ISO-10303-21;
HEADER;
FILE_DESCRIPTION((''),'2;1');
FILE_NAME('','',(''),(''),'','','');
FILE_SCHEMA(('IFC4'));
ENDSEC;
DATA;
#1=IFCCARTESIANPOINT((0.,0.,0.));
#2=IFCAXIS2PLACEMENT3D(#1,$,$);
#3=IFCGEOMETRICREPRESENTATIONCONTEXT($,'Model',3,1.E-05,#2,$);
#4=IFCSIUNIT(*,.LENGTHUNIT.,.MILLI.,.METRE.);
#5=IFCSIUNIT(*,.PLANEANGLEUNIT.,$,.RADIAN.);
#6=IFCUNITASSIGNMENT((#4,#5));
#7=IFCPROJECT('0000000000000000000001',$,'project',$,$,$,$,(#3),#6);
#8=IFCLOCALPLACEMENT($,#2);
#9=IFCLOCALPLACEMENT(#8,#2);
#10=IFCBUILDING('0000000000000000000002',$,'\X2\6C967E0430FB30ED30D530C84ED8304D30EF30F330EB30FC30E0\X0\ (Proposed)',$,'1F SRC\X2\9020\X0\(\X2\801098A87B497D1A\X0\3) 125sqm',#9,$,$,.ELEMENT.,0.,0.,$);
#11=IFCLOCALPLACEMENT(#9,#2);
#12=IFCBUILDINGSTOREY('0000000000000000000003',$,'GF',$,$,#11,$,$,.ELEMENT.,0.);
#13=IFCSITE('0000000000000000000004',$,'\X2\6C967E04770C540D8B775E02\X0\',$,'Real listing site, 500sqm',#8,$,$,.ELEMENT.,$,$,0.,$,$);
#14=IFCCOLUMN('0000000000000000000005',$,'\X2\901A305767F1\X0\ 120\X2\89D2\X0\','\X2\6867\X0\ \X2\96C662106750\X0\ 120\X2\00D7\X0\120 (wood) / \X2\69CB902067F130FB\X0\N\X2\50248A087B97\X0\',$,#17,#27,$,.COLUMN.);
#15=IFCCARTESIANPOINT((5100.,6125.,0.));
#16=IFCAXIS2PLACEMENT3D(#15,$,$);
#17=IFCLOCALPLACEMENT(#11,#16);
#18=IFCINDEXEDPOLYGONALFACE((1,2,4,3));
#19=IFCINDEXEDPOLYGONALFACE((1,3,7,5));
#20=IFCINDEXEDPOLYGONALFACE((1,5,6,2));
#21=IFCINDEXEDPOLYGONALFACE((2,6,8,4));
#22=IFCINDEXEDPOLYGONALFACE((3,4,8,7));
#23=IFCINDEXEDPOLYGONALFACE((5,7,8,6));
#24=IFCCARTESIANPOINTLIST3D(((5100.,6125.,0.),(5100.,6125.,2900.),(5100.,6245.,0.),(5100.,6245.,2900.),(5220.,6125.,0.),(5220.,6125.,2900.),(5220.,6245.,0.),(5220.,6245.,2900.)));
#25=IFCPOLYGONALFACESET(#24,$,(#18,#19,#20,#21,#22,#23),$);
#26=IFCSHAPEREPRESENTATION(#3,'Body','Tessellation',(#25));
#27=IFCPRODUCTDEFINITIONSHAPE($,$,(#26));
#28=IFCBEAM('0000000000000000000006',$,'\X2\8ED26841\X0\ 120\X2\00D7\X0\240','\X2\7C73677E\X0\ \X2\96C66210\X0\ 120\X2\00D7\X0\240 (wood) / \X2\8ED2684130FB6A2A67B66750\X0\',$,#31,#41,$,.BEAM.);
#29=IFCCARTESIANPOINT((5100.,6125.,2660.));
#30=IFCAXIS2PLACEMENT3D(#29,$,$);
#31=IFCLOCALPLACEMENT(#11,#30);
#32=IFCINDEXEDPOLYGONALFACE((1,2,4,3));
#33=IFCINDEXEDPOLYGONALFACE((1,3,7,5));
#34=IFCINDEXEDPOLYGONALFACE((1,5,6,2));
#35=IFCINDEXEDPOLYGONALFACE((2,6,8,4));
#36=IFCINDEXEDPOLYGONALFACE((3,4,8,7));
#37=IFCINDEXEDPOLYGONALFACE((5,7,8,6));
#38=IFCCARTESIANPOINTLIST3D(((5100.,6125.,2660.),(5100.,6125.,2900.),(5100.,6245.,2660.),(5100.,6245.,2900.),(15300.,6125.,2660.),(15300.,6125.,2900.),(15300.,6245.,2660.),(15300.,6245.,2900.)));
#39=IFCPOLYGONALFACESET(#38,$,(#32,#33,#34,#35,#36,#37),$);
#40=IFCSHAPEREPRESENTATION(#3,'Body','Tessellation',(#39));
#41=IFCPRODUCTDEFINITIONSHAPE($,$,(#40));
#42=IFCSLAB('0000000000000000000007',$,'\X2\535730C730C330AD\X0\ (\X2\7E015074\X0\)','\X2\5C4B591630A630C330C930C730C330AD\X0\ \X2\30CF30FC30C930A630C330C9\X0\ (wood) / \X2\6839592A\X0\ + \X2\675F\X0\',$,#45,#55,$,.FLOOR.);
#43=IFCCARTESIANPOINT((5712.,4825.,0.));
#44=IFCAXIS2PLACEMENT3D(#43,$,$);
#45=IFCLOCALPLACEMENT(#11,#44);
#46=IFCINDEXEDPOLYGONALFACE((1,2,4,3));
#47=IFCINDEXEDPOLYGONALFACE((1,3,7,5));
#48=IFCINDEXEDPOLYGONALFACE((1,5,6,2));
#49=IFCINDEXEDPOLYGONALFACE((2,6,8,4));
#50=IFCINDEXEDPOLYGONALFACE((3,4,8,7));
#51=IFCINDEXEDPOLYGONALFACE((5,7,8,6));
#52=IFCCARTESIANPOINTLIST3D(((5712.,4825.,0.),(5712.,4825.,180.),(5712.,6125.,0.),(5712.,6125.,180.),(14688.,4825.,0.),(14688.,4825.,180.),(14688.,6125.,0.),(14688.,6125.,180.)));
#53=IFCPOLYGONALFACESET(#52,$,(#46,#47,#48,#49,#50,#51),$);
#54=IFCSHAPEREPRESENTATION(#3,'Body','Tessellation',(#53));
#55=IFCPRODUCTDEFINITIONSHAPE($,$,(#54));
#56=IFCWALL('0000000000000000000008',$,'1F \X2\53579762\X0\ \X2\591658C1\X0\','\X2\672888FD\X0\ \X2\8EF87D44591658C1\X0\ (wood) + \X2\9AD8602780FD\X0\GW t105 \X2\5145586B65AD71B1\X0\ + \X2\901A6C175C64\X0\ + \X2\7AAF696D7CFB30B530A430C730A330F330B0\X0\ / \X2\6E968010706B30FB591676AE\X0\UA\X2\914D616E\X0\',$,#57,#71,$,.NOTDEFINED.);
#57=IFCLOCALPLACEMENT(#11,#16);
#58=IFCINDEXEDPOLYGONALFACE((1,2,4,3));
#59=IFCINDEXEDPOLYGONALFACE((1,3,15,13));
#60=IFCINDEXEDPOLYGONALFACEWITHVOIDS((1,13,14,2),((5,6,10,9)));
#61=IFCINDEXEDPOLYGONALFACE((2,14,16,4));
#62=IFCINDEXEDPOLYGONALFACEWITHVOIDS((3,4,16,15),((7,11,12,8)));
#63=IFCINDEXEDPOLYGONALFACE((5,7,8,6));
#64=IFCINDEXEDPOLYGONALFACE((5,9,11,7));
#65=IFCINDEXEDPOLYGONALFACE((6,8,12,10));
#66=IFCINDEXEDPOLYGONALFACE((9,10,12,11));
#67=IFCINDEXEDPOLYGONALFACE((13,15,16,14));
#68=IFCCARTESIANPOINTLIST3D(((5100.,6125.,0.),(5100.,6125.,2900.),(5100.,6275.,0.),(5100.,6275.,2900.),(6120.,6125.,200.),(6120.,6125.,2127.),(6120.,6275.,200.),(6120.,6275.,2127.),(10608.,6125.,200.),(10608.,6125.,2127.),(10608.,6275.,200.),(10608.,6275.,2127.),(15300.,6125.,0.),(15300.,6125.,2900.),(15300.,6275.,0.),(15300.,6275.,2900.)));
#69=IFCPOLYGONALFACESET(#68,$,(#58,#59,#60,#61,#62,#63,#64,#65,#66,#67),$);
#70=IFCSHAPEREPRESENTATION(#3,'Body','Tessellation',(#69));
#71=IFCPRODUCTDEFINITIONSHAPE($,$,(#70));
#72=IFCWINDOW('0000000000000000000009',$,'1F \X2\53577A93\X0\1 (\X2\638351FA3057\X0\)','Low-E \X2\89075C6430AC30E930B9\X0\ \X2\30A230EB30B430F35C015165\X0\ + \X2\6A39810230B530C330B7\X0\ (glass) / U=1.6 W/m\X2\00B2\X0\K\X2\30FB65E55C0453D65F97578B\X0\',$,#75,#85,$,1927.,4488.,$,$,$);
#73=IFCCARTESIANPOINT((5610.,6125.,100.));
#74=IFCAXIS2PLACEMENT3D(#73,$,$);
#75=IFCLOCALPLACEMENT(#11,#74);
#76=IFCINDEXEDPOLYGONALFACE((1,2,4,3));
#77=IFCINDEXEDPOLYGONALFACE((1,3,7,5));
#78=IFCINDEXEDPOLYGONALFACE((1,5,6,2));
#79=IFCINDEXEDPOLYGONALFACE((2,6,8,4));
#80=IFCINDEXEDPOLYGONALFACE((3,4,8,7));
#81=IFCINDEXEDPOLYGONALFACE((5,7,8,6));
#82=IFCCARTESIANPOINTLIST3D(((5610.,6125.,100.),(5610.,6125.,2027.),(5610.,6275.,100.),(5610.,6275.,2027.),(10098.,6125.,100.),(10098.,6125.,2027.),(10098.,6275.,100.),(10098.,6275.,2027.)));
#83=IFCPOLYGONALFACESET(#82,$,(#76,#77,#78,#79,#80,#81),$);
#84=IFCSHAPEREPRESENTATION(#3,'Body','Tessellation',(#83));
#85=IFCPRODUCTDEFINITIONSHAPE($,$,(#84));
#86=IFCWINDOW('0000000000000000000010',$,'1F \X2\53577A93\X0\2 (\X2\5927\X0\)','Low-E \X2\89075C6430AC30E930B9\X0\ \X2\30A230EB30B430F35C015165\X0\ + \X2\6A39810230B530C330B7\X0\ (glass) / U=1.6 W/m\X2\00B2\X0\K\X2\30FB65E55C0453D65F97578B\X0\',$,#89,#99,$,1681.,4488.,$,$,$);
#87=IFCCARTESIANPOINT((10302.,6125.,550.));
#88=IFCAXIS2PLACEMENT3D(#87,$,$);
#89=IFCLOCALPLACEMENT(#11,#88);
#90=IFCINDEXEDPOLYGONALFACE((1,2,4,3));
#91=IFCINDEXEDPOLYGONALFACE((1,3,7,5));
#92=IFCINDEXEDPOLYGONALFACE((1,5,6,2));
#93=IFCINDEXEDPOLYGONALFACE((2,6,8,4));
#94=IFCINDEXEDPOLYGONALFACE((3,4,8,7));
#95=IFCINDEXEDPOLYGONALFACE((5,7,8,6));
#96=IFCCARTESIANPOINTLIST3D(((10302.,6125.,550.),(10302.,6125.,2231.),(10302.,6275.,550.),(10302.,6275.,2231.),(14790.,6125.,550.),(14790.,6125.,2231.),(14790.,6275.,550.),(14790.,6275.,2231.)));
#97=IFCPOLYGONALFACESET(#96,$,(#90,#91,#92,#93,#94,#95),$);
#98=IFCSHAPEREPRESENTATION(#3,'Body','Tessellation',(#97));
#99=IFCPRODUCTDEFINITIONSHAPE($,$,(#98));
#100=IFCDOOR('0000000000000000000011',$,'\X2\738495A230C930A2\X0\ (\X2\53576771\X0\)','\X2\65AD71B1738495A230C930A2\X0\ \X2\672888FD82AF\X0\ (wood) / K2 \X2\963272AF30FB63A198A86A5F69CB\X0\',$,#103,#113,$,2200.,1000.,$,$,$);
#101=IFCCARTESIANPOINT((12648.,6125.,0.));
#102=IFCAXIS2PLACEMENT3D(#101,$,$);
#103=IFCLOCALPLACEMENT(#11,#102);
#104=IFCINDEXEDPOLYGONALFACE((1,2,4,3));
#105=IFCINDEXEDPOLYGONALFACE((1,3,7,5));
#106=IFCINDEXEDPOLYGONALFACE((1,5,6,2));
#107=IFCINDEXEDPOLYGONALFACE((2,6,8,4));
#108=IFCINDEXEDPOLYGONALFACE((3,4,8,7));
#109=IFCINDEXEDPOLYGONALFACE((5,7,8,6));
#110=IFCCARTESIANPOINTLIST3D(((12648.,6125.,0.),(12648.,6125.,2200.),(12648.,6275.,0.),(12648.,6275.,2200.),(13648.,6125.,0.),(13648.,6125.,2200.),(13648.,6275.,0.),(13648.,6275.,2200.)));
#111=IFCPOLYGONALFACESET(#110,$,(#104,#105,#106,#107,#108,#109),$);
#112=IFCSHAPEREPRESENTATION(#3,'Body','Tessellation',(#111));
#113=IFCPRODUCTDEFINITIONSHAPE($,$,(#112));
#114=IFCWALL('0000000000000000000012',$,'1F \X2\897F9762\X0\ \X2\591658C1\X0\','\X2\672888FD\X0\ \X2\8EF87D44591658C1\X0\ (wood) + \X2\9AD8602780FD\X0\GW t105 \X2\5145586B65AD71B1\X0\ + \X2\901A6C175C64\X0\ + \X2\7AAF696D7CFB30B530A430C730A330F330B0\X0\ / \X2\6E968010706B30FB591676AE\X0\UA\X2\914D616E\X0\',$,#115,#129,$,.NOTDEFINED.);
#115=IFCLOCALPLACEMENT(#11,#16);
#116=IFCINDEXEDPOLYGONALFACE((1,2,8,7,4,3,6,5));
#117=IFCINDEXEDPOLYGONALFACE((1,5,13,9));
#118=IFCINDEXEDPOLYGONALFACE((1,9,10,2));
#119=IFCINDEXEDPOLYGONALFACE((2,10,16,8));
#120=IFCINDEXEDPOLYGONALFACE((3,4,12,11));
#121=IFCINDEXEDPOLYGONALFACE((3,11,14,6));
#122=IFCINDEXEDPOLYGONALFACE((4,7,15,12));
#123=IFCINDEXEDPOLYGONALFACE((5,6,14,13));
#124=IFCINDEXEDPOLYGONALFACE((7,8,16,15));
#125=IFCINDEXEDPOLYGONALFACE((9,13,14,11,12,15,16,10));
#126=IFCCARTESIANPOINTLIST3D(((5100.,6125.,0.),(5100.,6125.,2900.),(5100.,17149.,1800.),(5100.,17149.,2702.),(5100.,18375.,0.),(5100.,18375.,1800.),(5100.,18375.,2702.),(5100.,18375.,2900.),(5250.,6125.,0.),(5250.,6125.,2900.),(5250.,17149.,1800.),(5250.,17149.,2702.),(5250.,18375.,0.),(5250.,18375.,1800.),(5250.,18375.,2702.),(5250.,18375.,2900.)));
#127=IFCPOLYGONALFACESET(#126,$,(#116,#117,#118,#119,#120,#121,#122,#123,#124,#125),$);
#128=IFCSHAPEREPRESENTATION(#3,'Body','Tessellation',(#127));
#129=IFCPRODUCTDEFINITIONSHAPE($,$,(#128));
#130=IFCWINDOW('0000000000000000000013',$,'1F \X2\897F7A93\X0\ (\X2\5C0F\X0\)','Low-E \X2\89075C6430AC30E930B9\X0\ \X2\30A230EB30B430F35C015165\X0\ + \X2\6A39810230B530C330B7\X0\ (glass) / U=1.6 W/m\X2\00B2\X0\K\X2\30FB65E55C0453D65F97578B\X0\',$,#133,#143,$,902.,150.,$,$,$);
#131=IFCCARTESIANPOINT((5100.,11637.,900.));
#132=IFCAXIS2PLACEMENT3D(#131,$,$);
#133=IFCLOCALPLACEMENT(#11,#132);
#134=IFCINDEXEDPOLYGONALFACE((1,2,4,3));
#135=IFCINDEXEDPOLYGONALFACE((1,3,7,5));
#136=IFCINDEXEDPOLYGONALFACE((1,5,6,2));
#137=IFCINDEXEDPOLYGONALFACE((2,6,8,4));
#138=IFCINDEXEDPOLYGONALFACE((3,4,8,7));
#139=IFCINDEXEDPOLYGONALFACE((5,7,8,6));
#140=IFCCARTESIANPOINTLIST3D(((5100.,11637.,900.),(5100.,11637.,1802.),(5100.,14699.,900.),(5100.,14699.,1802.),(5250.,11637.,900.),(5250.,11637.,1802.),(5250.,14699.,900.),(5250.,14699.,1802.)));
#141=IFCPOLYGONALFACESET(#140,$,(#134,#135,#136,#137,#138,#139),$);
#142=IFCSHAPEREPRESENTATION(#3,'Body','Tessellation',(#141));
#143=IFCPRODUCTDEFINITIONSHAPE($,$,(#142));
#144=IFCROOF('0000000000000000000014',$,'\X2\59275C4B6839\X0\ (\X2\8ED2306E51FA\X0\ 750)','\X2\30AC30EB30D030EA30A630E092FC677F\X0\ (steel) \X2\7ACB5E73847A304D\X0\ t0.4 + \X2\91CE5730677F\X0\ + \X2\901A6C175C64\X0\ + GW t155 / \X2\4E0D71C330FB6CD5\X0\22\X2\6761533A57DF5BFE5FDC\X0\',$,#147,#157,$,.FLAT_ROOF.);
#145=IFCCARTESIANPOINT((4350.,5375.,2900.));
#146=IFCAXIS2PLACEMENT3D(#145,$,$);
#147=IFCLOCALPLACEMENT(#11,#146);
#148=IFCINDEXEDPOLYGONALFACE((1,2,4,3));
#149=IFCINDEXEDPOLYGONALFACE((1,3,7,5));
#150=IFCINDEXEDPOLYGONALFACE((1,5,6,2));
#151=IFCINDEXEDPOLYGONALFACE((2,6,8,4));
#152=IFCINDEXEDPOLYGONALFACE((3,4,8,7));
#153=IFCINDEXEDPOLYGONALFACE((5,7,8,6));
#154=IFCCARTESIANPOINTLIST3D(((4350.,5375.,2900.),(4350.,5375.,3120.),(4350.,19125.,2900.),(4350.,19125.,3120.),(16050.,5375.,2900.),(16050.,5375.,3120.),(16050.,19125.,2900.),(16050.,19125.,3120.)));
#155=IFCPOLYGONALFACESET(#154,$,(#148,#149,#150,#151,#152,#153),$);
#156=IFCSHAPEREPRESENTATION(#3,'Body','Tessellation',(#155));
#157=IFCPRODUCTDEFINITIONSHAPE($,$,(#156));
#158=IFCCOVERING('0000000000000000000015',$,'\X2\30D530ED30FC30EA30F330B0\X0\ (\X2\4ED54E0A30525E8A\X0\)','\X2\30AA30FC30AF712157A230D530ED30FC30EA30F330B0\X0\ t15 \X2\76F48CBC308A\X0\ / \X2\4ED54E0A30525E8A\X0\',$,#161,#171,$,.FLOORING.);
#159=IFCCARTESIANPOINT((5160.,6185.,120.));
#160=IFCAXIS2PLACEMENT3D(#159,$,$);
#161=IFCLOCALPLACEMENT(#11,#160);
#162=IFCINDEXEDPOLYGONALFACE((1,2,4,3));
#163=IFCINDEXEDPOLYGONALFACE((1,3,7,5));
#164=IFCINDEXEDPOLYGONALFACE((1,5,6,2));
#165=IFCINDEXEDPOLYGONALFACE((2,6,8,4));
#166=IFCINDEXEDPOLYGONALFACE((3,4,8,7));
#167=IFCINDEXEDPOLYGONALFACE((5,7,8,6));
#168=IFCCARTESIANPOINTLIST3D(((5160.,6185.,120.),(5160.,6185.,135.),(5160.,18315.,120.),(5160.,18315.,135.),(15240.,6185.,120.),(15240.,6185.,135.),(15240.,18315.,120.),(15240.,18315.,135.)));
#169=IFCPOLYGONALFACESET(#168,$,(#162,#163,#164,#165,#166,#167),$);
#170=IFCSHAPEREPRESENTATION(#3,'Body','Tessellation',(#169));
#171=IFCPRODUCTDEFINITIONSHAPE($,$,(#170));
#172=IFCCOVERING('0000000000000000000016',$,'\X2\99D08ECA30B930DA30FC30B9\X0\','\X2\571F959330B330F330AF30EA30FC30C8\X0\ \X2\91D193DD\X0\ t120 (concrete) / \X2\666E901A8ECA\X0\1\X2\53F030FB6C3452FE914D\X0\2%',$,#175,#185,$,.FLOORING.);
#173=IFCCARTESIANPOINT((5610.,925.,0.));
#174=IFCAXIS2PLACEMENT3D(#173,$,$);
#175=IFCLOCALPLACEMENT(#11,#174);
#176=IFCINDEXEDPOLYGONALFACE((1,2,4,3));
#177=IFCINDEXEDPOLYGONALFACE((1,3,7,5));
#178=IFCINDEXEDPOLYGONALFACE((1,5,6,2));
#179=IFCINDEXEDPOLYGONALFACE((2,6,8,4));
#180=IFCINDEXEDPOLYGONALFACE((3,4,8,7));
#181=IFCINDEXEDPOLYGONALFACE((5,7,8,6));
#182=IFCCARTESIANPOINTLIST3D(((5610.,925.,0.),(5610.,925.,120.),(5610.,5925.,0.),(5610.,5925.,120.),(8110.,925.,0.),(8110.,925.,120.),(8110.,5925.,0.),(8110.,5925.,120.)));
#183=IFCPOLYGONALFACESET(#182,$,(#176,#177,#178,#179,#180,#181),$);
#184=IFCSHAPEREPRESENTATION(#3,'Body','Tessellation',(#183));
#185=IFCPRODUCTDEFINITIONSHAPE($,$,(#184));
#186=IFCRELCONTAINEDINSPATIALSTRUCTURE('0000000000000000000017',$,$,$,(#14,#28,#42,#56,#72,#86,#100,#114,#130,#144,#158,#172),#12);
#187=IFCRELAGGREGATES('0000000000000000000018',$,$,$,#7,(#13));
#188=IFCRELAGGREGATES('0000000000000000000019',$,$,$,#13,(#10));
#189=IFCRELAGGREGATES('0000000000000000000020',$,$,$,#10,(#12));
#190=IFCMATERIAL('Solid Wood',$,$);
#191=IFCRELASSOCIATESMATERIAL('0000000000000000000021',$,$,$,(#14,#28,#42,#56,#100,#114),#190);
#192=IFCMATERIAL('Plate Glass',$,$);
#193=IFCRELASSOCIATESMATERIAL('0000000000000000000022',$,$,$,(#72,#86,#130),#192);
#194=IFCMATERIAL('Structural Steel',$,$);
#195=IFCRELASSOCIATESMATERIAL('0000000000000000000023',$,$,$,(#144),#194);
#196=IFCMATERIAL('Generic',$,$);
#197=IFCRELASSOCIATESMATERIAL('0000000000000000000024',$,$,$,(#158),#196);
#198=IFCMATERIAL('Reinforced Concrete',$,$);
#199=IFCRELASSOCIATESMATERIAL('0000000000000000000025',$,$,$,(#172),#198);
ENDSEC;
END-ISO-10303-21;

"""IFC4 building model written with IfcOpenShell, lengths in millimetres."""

from ifc_helpers import new_model, si_unit, frame, frame_2d, origin, place, context, project, spatial, rectangle, extrude, material, element, fill, save


model = new_model("IFC4")

# Units and contexts
model_context = context("Model", 3, precision=1e-05, world=origin())
ifc_project = project(units=[si_unit("LENGTHUNIT", "METRE", prefix="MILLI"), si_unit("PLANEANGLEUNIT", "RADIAN")], contexts=[model_context])

# Site, building, storey
site_placement = place(None, origin())
site = spatial("IfcSite", under=ifc_project, at=site_placement, Name="沖縄県名護市", ObjectType="Real listing site, 500sqm", CompositionType="ELEMENT", RefElevation=0.0)
building_placement = place(site_placement, origin())
building = spatial("IfcBuilding", under=site, at=building_placement, Name="沖縄・ロフト付きワンルーム (Proposed)", ObjectType="1F SRC造(耐風等級3) 125sqm", CompositionType="ELEMENT", ElevationOfRefHeight=0.0, ElevationOfTerrain=0.0)
storey_placement = place(building_placement, origin())
storey = spatial("IfcBuildingStorey", under=building, at=storey_placement, Name="GF", CompositionType="ELEMENT", Elevation=0.0)

# Column
ifc_material_1 = material(Name="Solid Wood")
column_1_placement = place(storey_placement, frame((5100.0, 6125.0, 0.0)))
element("IfcColumn", 1, at=column_1_placement, inside=storey, material=ifc_material_1, Name="通し柱 120角", Description="桧 集成材 120×120 (wood) / 構造柱・N値計算", PredefinedType="COLUMN", context=model_context, shape_type="SweptSolid", body=[
    extrude(rectangle(XDim=120.0, YDim=120.0, at=frame_2d((60.0, 60.0))), frame((5100.0, 6125.0, 0.0)), (0.0, 0.0, 1.0), 2900.0),
])

# Beam
beam_1_placement = place(storey_placement, frame((5100.0, 6125.0, 2660.0)))
element("IfcBeam", 2, at=beam_1_placement, inside=storey, material=ifc_material_1, Name="軒桁 120×240", Description="米松 集成 120×240 (wood) / 軒桁・横架材", PredefinedType="BEAM", context=model_context, shape_type="SweptSolid", body=[
    extrude(rectangle(XDim=10200.0, YDim=120.0, at=frame_2d((5100.0, 60.0))), frame((5100.0, 6125.0, 2660.0)), (0.0, 0.0, 1.0), 240.0),
])

# Slab
ifc_material_2 = material(Name="Reinforced Concrete")
slab_1_placement = place(storey_placement, frame((5712.0, 4825.0, 0.0)))
element("IfcSlab", 3, at=slab_1_placement, inside=storey, material=ifc_material_1, Name="南デッキ (縁側)", Description="屋外ウッドデッキ ハードウッド (wood) / 根太 + 束", PredefinedType="FLOOR", context=model_context, shape_type="SweptSolid", body=[
    extrude(rectangle(XDim=8976.0, YDim=1300.0, at=frame_2d((4488.0, 650.0))), frame((5712.0, 4825.0, 0.0)), (0.0, 0.0, 1.0), 180.0),
])

# Wall, openings, windows, door
wall_1_placement = place(storey_placement, frame((5100.0, 6125.0, 0.0)))
wall_1 = element("IfcWall", 4, at=wall_1_placement, inside=storey, material=ifc_material_1, Name="1F 南面 外壁", Description="木製 軸組外壁 (wood) + 高性能GW t105 充填断熱 + 通気層 + 窯業系サイディング / 準耐火・外皮UA配慮", PredefinedType="NOTDEFINED", context=model_context, shape_type="SweptSolid", body=[
    extrude(rectangle(XDim=10200.0, YDim=150.0, at=frame_2d((5100.0, 75.0))), frame((5100.0, 6125.0, 0.0)), (0.0, 0.0, 1.0), 2900.0),
])
opening_1_placement = place(storey_placement, frame((5610.0, 6125.0, 100.0)))
opening_1 = element("IfcOpeningElement", 5, at=opening_1_placement, cuts=wall_1, PredefinedType="NOTDEFINED", context=model_context, shape_type="SweptSolid", body=[
    extrude(rectangle(XDim=4488.0, YDim=150.0, at=frame_2d((2244.0, 75.0))), frame((5610.0, 6125.0, 100.0)), (0.0, 0.0, 1.0), 1927.0),
])
opening_2_placement = place(storey_placement, frame((10302.0, 6125.0, 550.0)))
opening_2 = element("IfcOpeningElement", 6, at=opening_2_placement, cuts=wall_1, PredefinedType="NOTDEFINED", context=model_context, shape_type="SweptSolid", body=[
    extrude(rectangle(XDim=4488.0, YDim=150.0, at=frame_2d((2244.0, 75.0))), frame((10302.0, 6125.0, 550.0)), (0.0, 0.0, 1.0), 1681.0),
])
opening_3_placement = place(storey_placement, frame((12648.0, 6125.0, 0.0)))
opening_3 = element("IfcOpeningElement", 7, at=opening_3_placement, cuts=wall_1, PredefinedType="NOTDEFINED", context=model_context, shape_type="SweptSolid", body=[
    extrude(rectangle(XDim=1000.0, YDim=150.0, at=frame_2d((500.0, 75.0))), frame((12648.0, 6125.0, 0.0)), (0.0, 0.0, 1.0), 2200.0),
])
ifc_material_3 = material(Name="Plate Glass")
window_1_placement = place(storey_placement, frame((5610.0, 6125.0, 100.0)))
window_1 = element("IfcWindow", 8, at=window_1_placement, inside=storey, material=ifc_material_3, Name="1F 南窓1 (掃出し)", Description="Low-E 複層ガラス アルゴン封入 + 樹脂サッシ (glass) / U=1.6 W/m²K・日射取得型", OverallHeight=1927.0, OverallWidth=4488.0, context=model_context, shape_type="SweptSolid", body=[
    extrude(rectangle(XDim=4488.0, YDim=150.0, at=frame_2d((2244.0, 75.0))), frame((5610.0, 6125.0, 100.0)), (0.0, 0.0, 1.0), 1927.0),
])
fill(opening_1, window_1)
window_2_placement = place(storey_placement, frame((10302.0, 6125.0, 550.0)))
window_2 = element("IfcWindow", 9, at=window_2_placement, inside=storey, material=ifc_material_3, Name="1F 南窓2 (大)", Description="Low-E 複層ガラス アルゴン封入 + 樹脂サッシ (glass) / U=1.6 W/m²K・日射取得型", OverallHeight=1681.0, OverallWidth=4488.0, context=model_context, shape_type="SweptSolid", body=[
    extrude(rectangle(XDim=4488.0, YDim=150.0, at=frame_2d((2244.0, 75.0))), frame((10302.0, 6125.0, 550.0)), (0.0, 0.0, 1.0), 1681.0),
])
fill(opening_2, window_2)
door_placement = place(storey_placement, frame((12648.0, 6125.0, 0.0)))
door = element("IfcDoor", 10, at=door_placement, inside=storey, material=ifc_material_1, Name="玄関ドア (南東)", Description="断熱玄関ドア 木製芯 (wood) / K2 防犯・採風機構", OverallHeight=2200.0, OverallWidth=1000.0, context=model_context, shape_type="SweptSolid", body=[
    extrude(rectangle(XDim=1000.0, YDim=150.0, at=frame_2d((500.0, 75.0))), frame((12648.0, 6125.0, 0.0)), (0.0, 0.0, 1.0), 2200.0),
])
fill(opening_3, door)

# Wall, opening, window
wall_2_placement = place(storey_placement, frame((5100.0, 6125.0, 0.0)))
wall_2 = element("IfcWall", 11, at=wall_2_placement, inside=storey, material=ifc_material_1, Name="1F 西面 外壁", Description="木製 軸組外壁 (wood) + 高性能GW t105 充填断熱 + 通気層 + 窯業系サイディング / 準耐火・外皮UA配慮", PredefinedType="NOTDEFINED", context=model_context, shape_type="SweptSolid", body=[
    extrude(rectangle(XDim=150.0, YDim=12250.0, at=frame_2d((75.0, 6125.0))), frame((5100.0, 6125.0, 0.0)), (0.0, 0.0, 1.0), 2900.0),
])
opening_4_placement = place(storey_placement, frame((5100.0, 11637.0, 900.0)))
opening_4 = element("IfcOpeningElement", 12, at=opening_4_placement, cuts=wall_2, PredefinedType="NOTDEFINED", context=model_context, shape_type="SweptSolid", body=[
    extrude(rectangle(XDim=150.0, YDim=3062.0, at=frame_2d((75.0, 1531.0))), frame((5100.0, 11637.0, 900.0)), (0.0, 0.0, 1.0), 902.0),
])
window_3_placement = place(storey_placement, frame((5100.0, 11637.0, 900.0)))
window_3 = element("IfcWindow", 13, at=window_3_placement, inside=storey, material=ifc_material_3, Name="1F 西窓 (小)", Description="Low-E 複層ガラス アルゴン封入 + 樹脂サッシ (glass) / U=1.6 W/m²K・日射取得型", OverallHeight=902.0, OverallWidth=150.0, context=model_context, shape_type="SweptSolid", body=[
    extrude(rectangle(XDim=150.0, YDim=3062.0, at=frame_2d((75.0, 1531.0))), frame((5100.0, 11637.0, 900.0)), (0.0, 0.0, 1.0), 902.0),
])
fill(opening_4, window_3)

# Roof
ifc_material_4 = material(Name="Structural Steel")
roof_placement = place(storey_placement, frame((4350.0, 5375.0, 2900.0)))
element("IfcRoof", 14, at=roof_placement, inside=storey, material=ifc_material_4, Name="大屋根 (軒の出 750)", Description="ガルバリウム鋼板 (steel) 立平葺き t0.4 + 野地板 + 通気層 + GW t155 / 不燃・法22条区域対応", PredefinedType="FLAT_ROOF", context=model_context, shape_type="SweptSolid", body=[
    extrude(rectangle(XDim=11700.0, YDim=13750.0, at=frame_2d((5850.0, 6875.0))), frame((4350.0, 5375.0, 2900.0)), (0.0, 0.0, 1.0), 220.0),
])

# Coverings
ifc_material_5 = material(Name="Generic")
covering_1_placement = place(storey_placement, frame((5160.0, 6185.0, 120.0)))
element("IfcCovering", 15, at=covering_1_placement, inside=storey, material=ifc_material_5, Name="フローリング (仕上げ床)", Description="オーク無垢フローリング t15 直貼り / 仕上げ床", PredefinedType="FLOORING", context=model_context, shape_type="SweptSolid", body=[
    extrude(rectangle(XDim=10080.0, YDim=12130.0, at=frame_2d((5040.0, 6065.0))), frame((5160.0, 6185.0, 120.0)), (0.0, 0.0, 1.0), 15.0),
])
covering_2_placement = place(storey_placement, frame((5610.0, 925.0, 0.0)))
element("IfcCovering", 16, at=covering_2_placement, inside=storey, material=ifc_material_2, Name="駐車スペース", Description="土間コンクリート 金鏝 t120 (concrete) / 普通車1台・水勾配2%", PredefinedType="FLOORING", context=model_context, shape_type="SweptSolid", body=[
    extrude(rectangle(XDim=2500.0, YDim=5000.0, at=frame_2d((1250.0, 2500.0))), frame((5610.0, 925.0, 0.0)), (0.0, 0.0, 1.0), 120.0),
])

save(model, "model.ifc")
